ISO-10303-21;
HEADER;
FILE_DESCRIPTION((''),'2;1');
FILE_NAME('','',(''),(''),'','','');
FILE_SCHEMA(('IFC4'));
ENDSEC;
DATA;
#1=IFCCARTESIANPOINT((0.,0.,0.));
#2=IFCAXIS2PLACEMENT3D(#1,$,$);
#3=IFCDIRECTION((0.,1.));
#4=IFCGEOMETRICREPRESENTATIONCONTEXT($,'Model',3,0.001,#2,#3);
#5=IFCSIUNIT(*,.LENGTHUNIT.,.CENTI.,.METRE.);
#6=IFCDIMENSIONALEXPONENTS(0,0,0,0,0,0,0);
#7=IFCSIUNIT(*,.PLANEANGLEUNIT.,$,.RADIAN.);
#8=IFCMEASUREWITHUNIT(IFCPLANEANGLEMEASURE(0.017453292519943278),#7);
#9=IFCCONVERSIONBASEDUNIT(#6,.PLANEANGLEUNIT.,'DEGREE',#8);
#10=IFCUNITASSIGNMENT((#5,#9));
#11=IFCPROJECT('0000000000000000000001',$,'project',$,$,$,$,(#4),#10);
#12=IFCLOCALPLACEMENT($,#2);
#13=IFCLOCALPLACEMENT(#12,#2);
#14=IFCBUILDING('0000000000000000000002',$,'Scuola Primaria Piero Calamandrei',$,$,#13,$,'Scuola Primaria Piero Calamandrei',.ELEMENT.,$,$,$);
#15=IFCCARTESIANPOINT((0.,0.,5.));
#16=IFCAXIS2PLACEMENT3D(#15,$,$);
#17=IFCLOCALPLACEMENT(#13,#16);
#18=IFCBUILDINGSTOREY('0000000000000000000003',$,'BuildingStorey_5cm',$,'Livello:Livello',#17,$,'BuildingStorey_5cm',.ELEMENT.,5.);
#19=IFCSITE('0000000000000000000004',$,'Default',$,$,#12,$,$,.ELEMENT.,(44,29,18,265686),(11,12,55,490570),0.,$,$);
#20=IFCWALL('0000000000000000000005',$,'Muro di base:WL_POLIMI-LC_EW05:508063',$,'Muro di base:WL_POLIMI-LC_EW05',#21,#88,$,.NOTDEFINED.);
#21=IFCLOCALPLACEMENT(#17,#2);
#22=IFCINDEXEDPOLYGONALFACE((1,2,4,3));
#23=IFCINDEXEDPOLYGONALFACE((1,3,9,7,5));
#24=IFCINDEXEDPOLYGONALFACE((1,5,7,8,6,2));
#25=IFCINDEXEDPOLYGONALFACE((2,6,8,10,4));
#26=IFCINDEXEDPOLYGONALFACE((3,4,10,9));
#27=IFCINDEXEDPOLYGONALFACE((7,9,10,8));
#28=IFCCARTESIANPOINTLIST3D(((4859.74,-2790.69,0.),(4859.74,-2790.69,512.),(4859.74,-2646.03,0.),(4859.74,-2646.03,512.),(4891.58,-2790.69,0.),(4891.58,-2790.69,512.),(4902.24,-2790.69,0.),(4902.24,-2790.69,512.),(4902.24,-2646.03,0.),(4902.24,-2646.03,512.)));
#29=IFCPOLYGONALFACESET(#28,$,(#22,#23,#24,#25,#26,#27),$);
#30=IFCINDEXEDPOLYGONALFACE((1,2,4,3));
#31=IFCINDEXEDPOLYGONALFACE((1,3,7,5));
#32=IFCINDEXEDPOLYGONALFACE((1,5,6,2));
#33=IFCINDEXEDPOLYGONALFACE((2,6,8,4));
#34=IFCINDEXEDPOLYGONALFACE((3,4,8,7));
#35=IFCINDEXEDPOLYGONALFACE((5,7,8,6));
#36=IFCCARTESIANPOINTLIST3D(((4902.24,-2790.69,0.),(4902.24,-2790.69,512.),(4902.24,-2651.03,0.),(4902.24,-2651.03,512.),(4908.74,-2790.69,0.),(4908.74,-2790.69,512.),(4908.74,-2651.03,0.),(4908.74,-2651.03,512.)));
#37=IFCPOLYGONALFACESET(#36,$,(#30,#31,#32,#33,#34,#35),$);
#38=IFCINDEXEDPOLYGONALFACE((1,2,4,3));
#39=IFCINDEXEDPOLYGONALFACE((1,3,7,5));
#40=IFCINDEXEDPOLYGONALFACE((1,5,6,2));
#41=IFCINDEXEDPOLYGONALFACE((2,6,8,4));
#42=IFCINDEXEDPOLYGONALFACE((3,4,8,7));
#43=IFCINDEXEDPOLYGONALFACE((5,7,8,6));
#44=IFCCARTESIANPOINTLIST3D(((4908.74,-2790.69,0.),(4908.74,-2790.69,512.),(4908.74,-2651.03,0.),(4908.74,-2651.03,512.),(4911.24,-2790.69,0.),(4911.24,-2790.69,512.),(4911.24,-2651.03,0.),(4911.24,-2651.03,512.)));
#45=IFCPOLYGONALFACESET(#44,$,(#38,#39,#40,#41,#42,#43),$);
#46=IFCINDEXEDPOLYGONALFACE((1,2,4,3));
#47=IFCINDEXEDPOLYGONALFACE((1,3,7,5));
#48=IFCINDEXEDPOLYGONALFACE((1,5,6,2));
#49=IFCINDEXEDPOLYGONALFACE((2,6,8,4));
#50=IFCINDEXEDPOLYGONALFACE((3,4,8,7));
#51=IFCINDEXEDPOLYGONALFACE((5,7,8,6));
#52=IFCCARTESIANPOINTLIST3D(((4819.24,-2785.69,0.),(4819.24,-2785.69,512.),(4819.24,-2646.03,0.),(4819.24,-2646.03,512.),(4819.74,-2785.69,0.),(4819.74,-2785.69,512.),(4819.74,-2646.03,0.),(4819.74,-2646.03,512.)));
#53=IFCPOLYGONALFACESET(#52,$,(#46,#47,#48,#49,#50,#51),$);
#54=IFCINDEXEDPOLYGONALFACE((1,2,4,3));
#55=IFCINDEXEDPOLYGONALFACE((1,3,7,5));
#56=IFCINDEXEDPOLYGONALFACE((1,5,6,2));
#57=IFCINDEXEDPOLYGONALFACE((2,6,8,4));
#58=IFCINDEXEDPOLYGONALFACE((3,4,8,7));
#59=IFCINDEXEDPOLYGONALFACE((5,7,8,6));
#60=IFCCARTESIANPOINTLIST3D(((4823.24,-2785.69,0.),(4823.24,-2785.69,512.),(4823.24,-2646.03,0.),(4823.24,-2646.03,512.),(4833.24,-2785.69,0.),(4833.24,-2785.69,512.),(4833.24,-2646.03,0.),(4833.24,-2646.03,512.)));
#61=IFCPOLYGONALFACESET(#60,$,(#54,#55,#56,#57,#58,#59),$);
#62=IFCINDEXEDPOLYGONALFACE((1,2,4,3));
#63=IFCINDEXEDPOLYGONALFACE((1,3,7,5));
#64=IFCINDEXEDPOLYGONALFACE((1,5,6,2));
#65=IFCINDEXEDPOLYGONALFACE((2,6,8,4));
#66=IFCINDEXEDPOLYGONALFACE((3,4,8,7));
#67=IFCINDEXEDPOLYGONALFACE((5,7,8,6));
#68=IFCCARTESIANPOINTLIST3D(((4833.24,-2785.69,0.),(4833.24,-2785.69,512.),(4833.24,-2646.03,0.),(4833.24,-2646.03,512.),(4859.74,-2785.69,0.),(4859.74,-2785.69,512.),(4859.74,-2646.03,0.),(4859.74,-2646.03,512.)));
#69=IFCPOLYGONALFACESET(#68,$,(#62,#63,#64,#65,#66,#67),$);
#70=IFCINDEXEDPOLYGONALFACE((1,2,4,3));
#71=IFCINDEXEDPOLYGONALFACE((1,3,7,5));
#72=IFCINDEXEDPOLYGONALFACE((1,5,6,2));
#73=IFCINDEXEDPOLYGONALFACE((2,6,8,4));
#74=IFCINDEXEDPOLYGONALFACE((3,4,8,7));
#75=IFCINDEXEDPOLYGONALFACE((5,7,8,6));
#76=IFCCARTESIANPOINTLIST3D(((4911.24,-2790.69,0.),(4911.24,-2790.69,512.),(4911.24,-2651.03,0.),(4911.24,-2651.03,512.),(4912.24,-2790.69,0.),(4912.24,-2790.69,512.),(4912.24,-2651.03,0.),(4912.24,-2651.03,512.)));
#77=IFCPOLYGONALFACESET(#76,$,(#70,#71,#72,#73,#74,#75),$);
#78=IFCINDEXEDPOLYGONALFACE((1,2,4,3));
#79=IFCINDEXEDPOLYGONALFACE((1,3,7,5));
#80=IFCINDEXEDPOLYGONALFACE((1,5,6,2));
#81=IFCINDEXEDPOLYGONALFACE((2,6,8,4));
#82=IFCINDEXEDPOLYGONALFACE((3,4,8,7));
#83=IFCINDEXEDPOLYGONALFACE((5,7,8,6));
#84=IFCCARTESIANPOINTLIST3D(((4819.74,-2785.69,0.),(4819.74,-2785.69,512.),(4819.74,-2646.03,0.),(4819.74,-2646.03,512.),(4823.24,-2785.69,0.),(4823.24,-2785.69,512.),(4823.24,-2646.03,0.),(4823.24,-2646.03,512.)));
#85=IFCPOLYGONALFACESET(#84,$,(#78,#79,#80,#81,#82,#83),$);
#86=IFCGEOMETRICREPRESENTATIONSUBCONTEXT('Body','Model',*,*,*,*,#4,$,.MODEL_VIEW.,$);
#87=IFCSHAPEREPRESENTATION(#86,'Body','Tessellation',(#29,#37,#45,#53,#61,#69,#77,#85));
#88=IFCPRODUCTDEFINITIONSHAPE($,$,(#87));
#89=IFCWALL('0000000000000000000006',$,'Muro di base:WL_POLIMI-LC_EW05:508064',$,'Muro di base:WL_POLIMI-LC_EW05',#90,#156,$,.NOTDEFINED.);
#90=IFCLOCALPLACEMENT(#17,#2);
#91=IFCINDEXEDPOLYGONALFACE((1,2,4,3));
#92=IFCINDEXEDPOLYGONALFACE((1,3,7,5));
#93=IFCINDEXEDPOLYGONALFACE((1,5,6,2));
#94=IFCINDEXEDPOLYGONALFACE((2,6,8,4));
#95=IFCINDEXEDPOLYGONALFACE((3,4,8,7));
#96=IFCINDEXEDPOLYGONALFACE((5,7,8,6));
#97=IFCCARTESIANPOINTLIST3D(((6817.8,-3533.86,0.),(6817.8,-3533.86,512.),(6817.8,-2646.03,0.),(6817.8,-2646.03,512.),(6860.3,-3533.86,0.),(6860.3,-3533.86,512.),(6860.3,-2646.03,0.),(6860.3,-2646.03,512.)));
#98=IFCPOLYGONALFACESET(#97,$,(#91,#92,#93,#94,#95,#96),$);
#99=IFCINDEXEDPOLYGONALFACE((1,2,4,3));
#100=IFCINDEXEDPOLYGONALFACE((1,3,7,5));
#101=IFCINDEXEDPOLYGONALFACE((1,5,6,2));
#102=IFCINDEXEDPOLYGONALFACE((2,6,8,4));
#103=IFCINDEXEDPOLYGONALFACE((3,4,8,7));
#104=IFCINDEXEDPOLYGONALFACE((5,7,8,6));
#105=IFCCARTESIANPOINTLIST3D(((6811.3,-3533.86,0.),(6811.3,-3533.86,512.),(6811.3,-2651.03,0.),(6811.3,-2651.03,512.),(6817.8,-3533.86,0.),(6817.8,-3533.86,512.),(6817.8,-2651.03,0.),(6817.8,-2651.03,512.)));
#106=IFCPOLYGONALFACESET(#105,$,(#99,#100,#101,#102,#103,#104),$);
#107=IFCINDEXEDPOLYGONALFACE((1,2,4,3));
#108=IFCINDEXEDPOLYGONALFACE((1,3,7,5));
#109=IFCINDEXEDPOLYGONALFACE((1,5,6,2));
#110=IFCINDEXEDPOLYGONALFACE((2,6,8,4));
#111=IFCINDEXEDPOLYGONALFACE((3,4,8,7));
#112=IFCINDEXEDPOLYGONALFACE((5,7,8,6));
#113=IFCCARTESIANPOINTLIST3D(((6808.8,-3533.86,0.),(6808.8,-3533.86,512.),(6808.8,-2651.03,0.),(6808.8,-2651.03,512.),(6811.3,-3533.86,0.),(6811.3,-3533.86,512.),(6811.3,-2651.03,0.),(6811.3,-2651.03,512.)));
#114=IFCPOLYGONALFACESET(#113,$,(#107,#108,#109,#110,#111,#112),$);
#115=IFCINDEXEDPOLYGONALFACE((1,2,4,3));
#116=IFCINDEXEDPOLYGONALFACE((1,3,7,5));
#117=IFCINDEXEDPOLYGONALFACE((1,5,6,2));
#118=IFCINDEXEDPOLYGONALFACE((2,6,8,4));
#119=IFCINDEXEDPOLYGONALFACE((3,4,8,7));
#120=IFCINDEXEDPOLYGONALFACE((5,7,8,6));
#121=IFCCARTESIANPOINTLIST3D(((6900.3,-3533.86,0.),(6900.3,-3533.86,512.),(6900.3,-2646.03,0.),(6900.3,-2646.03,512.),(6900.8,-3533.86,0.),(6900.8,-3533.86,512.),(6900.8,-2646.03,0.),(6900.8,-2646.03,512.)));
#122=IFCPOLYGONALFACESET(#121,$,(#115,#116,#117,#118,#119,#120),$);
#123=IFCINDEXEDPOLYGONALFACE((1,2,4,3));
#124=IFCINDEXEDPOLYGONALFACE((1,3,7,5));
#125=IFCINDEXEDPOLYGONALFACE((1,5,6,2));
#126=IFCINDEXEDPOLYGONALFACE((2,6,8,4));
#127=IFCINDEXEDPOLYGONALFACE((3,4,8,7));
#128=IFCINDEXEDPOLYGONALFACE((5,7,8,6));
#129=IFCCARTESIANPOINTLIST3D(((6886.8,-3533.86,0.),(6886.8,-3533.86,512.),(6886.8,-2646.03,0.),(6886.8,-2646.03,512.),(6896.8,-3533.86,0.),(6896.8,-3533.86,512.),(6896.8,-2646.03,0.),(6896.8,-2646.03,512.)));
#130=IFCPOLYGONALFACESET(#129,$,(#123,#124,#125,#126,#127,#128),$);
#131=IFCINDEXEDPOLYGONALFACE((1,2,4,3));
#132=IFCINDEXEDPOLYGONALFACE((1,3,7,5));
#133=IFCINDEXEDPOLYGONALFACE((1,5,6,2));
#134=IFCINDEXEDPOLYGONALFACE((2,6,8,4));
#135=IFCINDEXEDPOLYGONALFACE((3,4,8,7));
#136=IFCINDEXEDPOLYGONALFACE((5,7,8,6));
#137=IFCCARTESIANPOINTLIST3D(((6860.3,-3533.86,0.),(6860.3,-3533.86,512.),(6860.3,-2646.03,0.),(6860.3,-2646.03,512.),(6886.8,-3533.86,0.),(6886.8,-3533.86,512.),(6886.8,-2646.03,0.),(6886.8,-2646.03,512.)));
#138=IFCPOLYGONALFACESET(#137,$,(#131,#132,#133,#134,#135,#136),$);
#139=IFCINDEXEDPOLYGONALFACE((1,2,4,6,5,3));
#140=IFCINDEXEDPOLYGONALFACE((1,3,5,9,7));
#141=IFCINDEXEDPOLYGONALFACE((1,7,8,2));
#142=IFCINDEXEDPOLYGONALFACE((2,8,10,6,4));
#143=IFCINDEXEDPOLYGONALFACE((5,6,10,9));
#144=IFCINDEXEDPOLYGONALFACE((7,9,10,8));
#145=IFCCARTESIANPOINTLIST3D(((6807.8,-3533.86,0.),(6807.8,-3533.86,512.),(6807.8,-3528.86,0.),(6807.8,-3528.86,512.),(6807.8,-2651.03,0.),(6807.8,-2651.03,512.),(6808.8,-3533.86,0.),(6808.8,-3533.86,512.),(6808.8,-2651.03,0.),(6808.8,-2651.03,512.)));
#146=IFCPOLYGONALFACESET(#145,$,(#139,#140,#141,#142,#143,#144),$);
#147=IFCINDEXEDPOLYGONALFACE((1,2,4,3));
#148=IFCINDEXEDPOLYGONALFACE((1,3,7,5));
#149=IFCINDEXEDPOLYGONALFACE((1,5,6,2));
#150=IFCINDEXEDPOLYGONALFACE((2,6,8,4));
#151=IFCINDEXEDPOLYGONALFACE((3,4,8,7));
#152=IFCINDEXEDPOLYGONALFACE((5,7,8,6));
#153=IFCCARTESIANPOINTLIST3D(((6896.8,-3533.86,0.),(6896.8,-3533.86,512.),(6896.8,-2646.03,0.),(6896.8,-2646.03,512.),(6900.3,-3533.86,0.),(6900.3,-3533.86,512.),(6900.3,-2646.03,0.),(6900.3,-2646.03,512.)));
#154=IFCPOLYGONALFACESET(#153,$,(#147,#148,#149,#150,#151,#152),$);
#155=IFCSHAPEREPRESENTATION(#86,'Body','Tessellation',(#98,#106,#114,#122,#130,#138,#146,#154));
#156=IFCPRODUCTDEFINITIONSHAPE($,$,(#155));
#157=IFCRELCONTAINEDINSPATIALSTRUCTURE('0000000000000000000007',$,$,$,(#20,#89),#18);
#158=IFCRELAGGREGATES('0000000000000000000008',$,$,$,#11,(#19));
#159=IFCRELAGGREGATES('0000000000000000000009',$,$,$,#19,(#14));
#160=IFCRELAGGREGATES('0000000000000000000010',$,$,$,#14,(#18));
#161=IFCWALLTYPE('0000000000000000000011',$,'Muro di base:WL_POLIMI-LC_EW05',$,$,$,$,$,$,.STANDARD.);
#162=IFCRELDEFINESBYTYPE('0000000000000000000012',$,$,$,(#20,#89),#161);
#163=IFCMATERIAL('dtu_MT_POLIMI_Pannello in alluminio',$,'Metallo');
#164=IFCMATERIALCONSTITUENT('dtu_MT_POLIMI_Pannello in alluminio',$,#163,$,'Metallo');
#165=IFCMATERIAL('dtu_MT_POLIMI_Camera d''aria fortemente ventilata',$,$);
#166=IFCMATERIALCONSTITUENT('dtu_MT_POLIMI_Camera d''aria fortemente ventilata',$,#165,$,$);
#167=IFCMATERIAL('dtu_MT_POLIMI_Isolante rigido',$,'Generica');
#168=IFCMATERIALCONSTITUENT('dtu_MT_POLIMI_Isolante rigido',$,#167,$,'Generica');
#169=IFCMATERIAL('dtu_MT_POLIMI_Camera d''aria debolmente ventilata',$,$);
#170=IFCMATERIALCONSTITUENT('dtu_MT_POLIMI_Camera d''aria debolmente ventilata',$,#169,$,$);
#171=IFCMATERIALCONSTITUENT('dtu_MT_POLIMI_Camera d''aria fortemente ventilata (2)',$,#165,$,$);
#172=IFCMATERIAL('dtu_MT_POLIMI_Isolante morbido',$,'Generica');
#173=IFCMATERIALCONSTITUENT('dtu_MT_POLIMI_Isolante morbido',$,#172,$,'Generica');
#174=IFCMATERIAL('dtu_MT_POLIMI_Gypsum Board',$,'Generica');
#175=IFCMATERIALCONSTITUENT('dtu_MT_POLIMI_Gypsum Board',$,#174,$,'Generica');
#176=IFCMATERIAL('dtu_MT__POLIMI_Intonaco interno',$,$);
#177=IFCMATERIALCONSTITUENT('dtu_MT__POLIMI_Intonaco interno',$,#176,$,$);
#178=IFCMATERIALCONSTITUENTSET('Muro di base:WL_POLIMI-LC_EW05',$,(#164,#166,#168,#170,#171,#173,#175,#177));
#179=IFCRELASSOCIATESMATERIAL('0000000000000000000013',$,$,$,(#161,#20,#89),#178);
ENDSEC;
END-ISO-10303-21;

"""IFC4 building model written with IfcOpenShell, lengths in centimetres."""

from ifc_helpers import new_model, entity, si_unit, converted_unit, direction, frame, origin, place, context, subcontext, project, spatial, indexed_curve, outline, extrude, material, constituent, constituent_set, type_object, element, save


model = new_model("IFC4")

# Units and contexts
model_context = context("Model", 3, precision=0.001, world=origin(), true_north=direction((0.0, 1.0)))
body_context = subcontext(model_context, "Body", "Model", "MODEL_VIEW")
ifc_project = project(units=[si_unit("LENGTHUNIT", "METRE", prefix="CENTI"), converted_unit("PLANEANGLEUNIT", "DEGREE", entity("IfcPlaneAngleMeasure", 0.017453292519943278), si_unit("PLANEANGLEUNIT", "RADIAN"), dimensions=[0, 0, 0, 0, 0, 0, 0])], contexts=[model_context])

# Site, building, storey
site_placement = place(None, origin())
site = spatial("IfcSite", under=ifc_project, at=site_placement, Name="Default", CompositionType="ELEMENT", RefLatitude=(44, 29, 18, 265686), RefLongitude=(11, 12, 55, 490570), RefElevation=0.0)
building_placement = place(site_placement, origin())
building = spatial("IfcBuilding", under=site, at=building_placement, Name="Scuola Primaria Piero Calamandrei", LongName="Scuola Primaria Piero Calamandrei", CompositionType="ELEMENT")
storey_placement = place(building_placement, frame((0.0, 0.0, 5.0)))
storey = spatial("IfcBuildingStorey", under=building, at=storey_placement, Name="BuildingStorey_5cm", ObjectType="Livello:Livello", LongName="BuildingStorey_5cm", CompositionType="ELEMENT", Elevation=5.0)

# Shared definitions
ifc_material_1 = material(Name="dtu_MT_POLIMI_Isolante rigido", Category="Generica")

# Walls
ifc_material_2 = material(Name="dtu_MT_POLIMI_Pannello in alluminio", Category="Metallo")
ifc_constituent_1 = constituent(ifc_material_2, Name="dtu_MT_POLIMI_Pannello in alluminio", Category="Metallo")
ifc_material_3 = material(Name="dtu_MT_POLIMI_Camera d'aria fortemente ventilata")
ifc_constituent_2 = constituent(ifc_material_3, Name="dtu_MT_POLIMI_Camera d'aria fortemente ventilata")
ifc_constituent_3 = constituent(ifc_material_1, Name="dtu_MT_POLIMI_Isolante rigido", Category="Generica")
ifc_material_4 = material(Name="dtu_MT_POLIMI_Camera d'aria debolmente ventilata")
ifc_constituent_4 = constituent(ifc_material_4, Name="dtu_MT_POLIMI_Camera d'aria debolmente ventilata")
ifc_constituent_5 = constituent(ifc_material_3, Name="dtu_MT_POLIMI_Camera d'aria fortemente ventilata (2)")
ifc_material_5 = material(Name="dtu_MT_POLIMI_Isolante morbido", Category="Generica")
ifc_constituent_6 = constituent(ifc_material_5, Name="dtu_MT_POLIMI_Isolante morbido", Category="Generica")
ifc_material_6 = material(Name="dtu_MT_POLIMI_Gypsum Board", Category="Generica")
ifc_constituent_7 = constituent(ifc_material_6, Name="dtu_MT_POLIMI_Gypsum Board", Category="Generica")
ifc_material_7 = material(Name="dtu_MT__POLIMI_Intonaco interno")
ifc_constituent_8 = constituent(ifc_material_7, Name="dtu_MT__POLIMI_Intonaco interno")
ifc_constituent_set_1 = constituent_set(constituents=[ifc_constituent_1, ifc_constituent_2, ifc_constituent_3, ifc_constituent_4, ifc_constituent_5, ifc_constituent_6, ifc_constituent_7, ifc_constituent_8], Name="Muro di base:WL_POLIMI-LC_EW05")
wall_type_1 = type_object("IfcWallType", Name="Muro di base:WL_POLIMI-LC_EW05", PredefinedType="STANDARD", material=ifc_constituent_set_1)
wall_1_placement = place(storey_placement, frame((4865.74, -2790.69, 0.0), z_axis=(0.0, 0.0, 1.0), x_axis=(0.0, 1.0, 0.0)))
element("IfcWall", 1, at=wall_1_placement, inside=storey, type_object=wall_type_1, material=ifc_constituent_set_1, Name="Muro di base:WL_POLIMI-LC_EW05:508063", ObjectType="Muro di base:WL_POLIMI-LC_EW05", PredefinedType="NOTDEFINED", context=body_context, shape_type="SweptSolid", body=[
    extrude(outline(indexed_curve([(-57.86, -19.13), (86.79, -19.13), (86.79, 23.37), (-57.86, 23.37), (-57.86, -8.47), (-57.86, -19.13)], self_intersect=False)), frame((57.86, -17.37, 0.0)), (0.0, 0.0, 1.0), 512.0),
    extrude(outline(indexed_curve([(-69.83, -3.25), (69.83, -3.25), (69.83, 3.25), (-69.83, 3.25), (-69.83, -3.25)], self_intersect=False)), frame((69.83, -39.75, 0.0)), (0.0, 0.0, 1.0), 512.0),
    extrude(outline(indexed_curve([(-69.83, -1.25), (69.83, -1.25), (69.83, 1.25), (-69.83, 1.25), (-69.83, -1.25)], self_intersect=False)), frame((69.83, -44.25, 0.0)), (0.0, 0.0, 1.0), 512.0),
    extrude(outline(indexed_curve([(-0.25, -69.83), (0.25, -69.83), (0.25, 69.83), (-0.25, 69.83), (-0.25, -69.83)], self_intersect=False)), frame((74.83, 46.25, 0.0), z_axis=(0.0, 0.0, 1.0), x_axis=(0.0, -1.0, 0.0)), (0.0, 0.0, 1.0), 512.0),
    extrude(outline(indexed_curve([(-69.83, -5.0), (69.83, -5.0), (69.83, 5.0), (-69.83, 5.0), (-69.83, -5.0)], self_intersect=False)), frame((74.83, 37.5, 0.0)), (0.0, 0.0, 1.0), 512.0),
    extrude(outline(indexed_curve([(-69.83, -13.25), (69.83, -13.25), (69.83, 13.25), (-69.83, 13.25), (-69.83, -13.25)], self_intersect=False)), frame((74.83, 19.25, 0.0)), (0.0, 0.0, 1.0), 512.0),
    extrude(outline(indexed_curve([(-0.5, -69.83), (0.5, -69.83), (0.5, 69.83), (-0.5, 69.83), (-0.5, -69.83)], self_intersect=False)), frame((69.83, -46.0, 0.0), z_axis=(0.0, 0.0, 1.0), x_axis=(0.0, 1.0, 0.0)), (0.0, 0.0, 1.0), 512.0),
    extrude(outline(indexed_curve([(-69.83, -1.75), (69.83, -1.75), (69.83, 1.75), (-69.83, 1.75), (-69.83, -1.75)], self_intersect=False)), frame((74.83, 44.25, 0.0)), (0.0, 0.0, 1.0), 512.0),
])
wall_2_placement = place(storey_placement, frame((6854.3, -2646.03, 0.0), z_axis=(0.0, 0.0, 1.0), x_axis=(0.0, -1.0, 0.0)))
element("IfcWall", 2, at=wall_2_placement, inside=storey, type_object=wall_type_1, material=ifc_constituent_set_1, Name="Muro di base:WL_POLIMI-LC_EW05:508064", ObjectType="Muro di base:WL_POLIMI-LC_EW05", PredefinedType="NOTDEFINED", context=body_context, shape_type="SweptSolid", body=[
    extrude(outline(indexed_curve([(-443.91, -21.25), (443.91, -21.25), (443.91, 21.25), (-443.91, 21.25), (-443.91, -21.25)], self_intersect=False)), frame((443.91, -15.25, 0.0)), (0.0, 0.0, 1.0), 512.0),
    extrude(outline(indexed_curve([(-441.41, -3.25), (441.41, -3.25), (441.41, 3.25), (-441.41, 3.25), (-441.41, -3.25)], self_intersect=False)), frame((446.41, -39.75, 0.0)), (0.0, 0.0, 1.0), 512.0),
    extrude(outline(indexed_curve([(-441.41, -1.25), (441.41, -1.25), (441.41, 1.25), (-441.41, 1.25), (-441.41, -1.25)], self_intersect=False)), frame((446.41, -44.25, 0.0)), (0.0, 0.0, 1.0), 512.0),
    extrude(outline(indexed_curve([(-0.25, -443.91), (0.25, -443.91), (0.25, 443.91), (-0.25, 443.91), (-0.25, -443.91)], self_intersect=False)), frame((443.91, 46.25, 0.0), z_axis=(0.0, 0.0, 1.0), x_axis=(0.0, -1.0, 0.0)), (0.0, 0.0, 1.0), 512.0),
    extrude(outline(indexed_curve([(-443.91, -5.0), (443.91, -5.0), (443.91, 5.0), (-443.91, 5.0), (-443.91, -5.0)], self_intersect=False)), frame((443.91, 37.5, 0.0)), (0.0, 0.0, 1.0), 512.0),
    extrude(outline(indexed_curve([(-443.91, -13.25), (443.91, -13.25), (443.91, 13.25), (-443.91, 13.25), (-443.91, -13.25)], self_intersect=False)), frame((443.91, 19.25, 0.0)), (0.0, 0.0, 1.0), 512.0),
    extrude(outline(indexed_curve([(-528.69, -0.4), (349.13, -0.4), (354.13, -0.4), (354.13, 0.6), (-528.69, 0.6), (-528.69, -0.4)], self_intersect=False)), frame((533.69, -46.1, 0.0)), (0.0, 0.0, 1.0), 512.0),
    extrude(outline(indexed_curve([(-443.91, -1.75), (443.91, -1.75), (443.91, 1.75), (-443.91, 1.75), (-443.91, -1.75)], self_intersect=False)), frame((443.91, 44.25, 0.0)), (0.0, 0.0, 1.0), 512.0),
])

save(model, "model.ifc")
